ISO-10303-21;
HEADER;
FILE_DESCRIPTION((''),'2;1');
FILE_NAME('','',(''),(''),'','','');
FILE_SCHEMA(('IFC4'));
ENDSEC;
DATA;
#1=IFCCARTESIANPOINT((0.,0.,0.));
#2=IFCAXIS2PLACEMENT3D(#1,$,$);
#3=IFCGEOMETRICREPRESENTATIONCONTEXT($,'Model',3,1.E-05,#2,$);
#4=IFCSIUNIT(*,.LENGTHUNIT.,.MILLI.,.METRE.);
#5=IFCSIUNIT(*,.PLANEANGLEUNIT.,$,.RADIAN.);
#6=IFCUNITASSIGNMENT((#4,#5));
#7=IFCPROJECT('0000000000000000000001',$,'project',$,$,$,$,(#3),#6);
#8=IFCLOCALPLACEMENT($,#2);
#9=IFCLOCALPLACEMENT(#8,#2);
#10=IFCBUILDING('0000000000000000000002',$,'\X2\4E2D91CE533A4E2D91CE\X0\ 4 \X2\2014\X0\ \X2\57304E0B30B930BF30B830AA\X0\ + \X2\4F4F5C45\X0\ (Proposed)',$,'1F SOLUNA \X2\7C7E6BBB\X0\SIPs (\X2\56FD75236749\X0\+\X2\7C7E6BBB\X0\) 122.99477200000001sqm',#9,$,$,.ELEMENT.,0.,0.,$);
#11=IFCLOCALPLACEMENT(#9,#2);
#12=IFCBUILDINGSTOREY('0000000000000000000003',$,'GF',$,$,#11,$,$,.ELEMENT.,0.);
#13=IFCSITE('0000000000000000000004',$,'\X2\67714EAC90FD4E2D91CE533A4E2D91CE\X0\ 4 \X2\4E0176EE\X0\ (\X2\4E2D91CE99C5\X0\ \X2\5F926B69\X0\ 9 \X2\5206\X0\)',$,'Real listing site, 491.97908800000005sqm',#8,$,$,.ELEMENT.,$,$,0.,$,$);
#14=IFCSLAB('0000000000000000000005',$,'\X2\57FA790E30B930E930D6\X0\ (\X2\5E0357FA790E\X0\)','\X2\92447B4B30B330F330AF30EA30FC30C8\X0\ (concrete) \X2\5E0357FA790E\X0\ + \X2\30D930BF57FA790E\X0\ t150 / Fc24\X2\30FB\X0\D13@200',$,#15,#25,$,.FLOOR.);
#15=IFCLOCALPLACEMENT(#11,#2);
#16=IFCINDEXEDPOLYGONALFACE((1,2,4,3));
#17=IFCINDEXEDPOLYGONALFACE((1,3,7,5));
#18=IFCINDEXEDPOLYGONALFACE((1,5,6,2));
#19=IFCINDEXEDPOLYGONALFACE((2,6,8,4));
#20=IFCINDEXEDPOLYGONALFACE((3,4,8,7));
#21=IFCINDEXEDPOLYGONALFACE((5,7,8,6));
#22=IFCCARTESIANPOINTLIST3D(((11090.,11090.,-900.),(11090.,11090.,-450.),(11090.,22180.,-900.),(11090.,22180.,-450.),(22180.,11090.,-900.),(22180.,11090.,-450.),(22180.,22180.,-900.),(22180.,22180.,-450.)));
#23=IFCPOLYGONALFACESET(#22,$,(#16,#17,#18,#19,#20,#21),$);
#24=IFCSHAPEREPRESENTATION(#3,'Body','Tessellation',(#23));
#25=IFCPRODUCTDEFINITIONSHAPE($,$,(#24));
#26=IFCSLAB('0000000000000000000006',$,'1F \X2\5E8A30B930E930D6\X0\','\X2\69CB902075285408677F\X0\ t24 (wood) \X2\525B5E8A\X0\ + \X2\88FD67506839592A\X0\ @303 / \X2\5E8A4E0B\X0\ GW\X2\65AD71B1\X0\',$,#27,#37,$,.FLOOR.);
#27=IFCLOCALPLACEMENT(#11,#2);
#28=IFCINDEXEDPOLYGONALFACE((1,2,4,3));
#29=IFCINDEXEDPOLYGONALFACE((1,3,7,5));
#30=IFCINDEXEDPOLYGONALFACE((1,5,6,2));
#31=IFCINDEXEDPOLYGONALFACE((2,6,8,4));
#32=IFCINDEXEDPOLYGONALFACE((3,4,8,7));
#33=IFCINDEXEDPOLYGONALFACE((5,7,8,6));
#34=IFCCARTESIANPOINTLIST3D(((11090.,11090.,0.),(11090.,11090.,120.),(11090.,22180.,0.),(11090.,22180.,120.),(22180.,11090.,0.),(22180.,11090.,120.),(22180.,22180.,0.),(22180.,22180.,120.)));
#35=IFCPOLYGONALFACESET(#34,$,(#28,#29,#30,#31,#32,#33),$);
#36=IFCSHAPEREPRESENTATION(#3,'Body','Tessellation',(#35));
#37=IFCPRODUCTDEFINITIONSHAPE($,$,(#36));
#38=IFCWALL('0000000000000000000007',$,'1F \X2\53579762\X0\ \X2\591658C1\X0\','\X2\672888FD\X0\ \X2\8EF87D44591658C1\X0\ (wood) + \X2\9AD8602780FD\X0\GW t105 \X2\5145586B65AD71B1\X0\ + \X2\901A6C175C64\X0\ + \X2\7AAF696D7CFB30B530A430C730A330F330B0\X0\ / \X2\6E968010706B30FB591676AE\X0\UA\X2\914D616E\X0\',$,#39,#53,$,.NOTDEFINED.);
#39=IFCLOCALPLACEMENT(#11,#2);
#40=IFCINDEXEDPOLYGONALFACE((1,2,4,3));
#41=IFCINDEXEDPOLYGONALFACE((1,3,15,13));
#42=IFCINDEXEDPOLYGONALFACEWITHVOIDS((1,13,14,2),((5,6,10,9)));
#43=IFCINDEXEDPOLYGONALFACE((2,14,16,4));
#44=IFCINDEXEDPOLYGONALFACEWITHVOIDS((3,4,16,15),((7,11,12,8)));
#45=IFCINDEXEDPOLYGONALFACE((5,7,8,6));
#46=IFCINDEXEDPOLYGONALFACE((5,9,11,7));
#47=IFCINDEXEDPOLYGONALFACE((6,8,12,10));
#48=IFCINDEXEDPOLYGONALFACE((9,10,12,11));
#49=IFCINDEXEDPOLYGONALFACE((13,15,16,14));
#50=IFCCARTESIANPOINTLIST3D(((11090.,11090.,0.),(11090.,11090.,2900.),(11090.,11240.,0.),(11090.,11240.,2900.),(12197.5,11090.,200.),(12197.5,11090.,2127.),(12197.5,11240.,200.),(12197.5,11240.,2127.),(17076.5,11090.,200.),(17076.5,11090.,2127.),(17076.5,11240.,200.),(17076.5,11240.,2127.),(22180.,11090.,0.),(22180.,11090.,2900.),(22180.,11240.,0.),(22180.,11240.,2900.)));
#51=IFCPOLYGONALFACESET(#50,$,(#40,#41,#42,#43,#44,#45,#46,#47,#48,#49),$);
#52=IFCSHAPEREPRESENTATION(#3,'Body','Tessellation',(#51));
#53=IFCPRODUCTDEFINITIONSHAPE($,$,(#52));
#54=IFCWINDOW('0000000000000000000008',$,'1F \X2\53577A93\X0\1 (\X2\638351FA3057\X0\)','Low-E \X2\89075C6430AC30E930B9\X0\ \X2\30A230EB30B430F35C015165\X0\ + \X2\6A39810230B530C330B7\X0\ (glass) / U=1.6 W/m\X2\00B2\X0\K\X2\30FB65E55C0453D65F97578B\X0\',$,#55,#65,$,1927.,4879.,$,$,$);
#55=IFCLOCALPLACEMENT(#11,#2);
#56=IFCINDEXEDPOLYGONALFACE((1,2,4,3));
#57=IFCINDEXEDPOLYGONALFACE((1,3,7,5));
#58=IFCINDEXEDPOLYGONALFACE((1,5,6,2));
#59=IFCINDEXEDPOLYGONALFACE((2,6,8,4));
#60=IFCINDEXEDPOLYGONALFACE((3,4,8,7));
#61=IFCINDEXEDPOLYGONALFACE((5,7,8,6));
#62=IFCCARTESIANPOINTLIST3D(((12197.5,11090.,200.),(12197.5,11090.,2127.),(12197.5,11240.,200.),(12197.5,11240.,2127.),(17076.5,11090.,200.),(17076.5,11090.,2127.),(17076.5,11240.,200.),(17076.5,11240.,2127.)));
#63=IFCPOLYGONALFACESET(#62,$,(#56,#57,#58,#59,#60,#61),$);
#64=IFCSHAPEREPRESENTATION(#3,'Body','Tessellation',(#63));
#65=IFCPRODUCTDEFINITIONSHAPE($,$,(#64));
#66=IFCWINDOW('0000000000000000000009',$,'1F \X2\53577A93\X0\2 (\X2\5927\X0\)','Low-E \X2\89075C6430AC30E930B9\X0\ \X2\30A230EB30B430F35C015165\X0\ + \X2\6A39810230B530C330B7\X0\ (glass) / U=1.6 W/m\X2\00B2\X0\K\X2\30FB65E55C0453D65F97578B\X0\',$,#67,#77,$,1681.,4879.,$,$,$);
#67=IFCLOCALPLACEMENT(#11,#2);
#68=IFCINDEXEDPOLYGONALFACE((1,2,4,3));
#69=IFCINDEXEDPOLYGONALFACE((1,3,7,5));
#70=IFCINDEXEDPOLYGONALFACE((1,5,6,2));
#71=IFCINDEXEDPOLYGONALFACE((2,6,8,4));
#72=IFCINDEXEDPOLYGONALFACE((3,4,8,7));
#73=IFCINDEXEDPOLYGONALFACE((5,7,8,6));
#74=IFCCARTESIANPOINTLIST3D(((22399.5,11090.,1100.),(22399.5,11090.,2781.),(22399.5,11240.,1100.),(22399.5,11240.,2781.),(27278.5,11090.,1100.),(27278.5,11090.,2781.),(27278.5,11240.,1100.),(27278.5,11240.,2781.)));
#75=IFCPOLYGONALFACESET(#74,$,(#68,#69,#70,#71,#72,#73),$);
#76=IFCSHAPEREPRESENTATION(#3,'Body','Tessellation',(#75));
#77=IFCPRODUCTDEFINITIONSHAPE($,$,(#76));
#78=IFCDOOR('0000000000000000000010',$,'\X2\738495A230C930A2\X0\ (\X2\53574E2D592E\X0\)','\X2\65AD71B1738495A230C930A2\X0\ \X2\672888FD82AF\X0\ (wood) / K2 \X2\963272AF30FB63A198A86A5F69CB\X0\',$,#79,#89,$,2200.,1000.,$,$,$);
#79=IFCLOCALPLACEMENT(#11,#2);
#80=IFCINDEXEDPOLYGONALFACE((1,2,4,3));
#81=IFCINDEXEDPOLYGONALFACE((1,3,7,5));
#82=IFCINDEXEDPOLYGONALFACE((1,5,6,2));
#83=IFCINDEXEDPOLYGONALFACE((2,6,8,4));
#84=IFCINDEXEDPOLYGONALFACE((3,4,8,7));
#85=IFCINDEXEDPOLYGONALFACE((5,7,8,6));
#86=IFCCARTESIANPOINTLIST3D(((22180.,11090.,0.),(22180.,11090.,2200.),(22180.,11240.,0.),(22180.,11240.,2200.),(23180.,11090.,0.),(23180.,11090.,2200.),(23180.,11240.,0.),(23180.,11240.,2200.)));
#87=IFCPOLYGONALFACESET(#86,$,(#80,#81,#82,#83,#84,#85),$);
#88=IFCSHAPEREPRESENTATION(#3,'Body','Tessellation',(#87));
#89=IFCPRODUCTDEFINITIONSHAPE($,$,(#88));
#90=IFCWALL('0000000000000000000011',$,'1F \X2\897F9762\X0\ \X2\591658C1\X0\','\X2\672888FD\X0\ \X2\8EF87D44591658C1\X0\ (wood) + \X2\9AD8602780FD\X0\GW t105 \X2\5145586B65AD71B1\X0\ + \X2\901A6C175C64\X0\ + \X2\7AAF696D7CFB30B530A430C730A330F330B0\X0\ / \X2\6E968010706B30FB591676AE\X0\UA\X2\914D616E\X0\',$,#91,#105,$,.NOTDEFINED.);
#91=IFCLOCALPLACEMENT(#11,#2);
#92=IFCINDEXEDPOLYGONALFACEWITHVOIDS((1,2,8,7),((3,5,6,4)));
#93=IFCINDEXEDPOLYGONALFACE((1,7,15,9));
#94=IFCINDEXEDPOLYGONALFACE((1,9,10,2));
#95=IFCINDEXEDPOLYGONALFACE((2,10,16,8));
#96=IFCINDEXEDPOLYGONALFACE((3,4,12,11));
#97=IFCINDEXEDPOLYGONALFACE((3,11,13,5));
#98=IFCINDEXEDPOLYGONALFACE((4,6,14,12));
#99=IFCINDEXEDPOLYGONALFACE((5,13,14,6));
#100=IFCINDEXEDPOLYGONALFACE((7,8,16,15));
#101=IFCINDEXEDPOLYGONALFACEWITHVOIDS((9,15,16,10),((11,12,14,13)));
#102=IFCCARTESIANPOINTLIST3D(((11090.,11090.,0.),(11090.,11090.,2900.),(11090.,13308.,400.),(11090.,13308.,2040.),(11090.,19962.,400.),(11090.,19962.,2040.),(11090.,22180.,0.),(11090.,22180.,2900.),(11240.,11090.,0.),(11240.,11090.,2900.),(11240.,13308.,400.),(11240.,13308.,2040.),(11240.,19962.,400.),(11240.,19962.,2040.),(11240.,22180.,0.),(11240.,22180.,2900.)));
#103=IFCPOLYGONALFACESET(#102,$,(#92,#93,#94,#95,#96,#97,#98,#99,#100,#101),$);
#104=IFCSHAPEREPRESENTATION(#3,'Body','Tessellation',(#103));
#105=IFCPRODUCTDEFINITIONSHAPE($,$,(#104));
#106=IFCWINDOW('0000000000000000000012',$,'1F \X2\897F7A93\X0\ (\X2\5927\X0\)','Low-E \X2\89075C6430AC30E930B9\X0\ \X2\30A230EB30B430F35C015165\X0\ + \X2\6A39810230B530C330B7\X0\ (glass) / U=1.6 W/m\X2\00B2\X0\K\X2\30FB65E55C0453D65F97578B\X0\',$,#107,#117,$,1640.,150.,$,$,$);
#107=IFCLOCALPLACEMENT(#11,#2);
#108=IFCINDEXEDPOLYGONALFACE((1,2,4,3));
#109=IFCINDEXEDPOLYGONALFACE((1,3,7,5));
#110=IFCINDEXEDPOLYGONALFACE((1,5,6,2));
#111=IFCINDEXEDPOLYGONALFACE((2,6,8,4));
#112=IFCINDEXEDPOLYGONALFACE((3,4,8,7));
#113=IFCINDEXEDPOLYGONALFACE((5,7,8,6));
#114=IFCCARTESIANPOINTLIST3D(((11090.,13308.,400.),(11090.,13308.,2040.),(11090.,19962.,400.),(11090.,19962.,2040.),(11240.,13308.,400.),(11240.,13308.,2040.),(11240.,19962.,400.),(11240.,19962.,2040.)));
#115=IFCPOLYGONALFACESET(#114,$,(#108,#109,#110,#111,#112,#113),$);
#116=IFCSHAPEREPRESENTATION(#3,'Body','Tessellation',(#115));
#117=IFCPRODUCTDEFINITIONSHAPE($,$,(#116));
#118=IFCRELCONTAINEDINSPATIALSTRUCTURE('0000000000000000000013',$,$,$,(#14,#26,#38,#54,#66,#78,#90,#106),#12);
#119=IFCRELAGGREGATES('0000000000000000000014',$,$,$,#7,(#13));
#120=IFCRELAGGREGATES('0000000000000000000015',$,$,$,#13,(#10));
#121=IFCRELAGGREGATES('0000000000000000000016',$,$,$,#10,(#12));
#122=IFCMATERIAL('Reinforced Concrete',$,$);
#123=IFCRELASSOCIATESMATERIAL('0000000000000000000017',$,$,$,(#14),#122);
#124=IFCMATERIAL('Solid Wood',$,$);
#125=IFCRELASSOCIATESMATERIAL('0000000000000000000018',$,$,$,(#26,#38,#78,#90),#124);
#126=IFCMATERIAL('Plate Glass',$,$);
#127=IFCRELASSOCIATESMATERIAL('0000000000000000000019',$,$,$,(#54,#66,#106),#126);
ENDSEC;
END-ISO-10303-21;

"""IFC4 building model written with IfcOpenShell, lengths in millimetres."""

from ifc_helpers import new_model, si_unit, frame, frame_2d, origin, place, context, project, spatial, rectangle, extrude, material, element, fill, save


model = new_model("IFC4")

# Units and contexts
model_context = context("Model", 3, precision=1e-05, world=origin())
ifc_project = project(units=[si_unit("LENGTHUNIT", "METRE", prefix="MILLI"), si_unit("PLANEANGLEUNIT", "RADIAN")], contexts=[model_context])

# Site, building, storey
site_placement = place(None, origin())
site = spatial("IfcSite", under=ifc_project, at=site_placement, Name="東京都中野区中野 4 丁目 (中野駅 徒歩 9 分)", ObjectType="Real listing site, 491.97908800000005sqm", CompositionType="ELEMENT", RefElevation=0.0)
building_placement = place(site_placement, origin())
building = spatial("IfcBuilding", under=site, at=building_placement, Name="中野区中野 4 — 地下スタジオ + 住居 (Proposed)", ObjectType="1F SOLUNA 籾殻SIPs (国産杉+籾殻) 122.99477200000001sqm", CompositionType="ELEMENT", ElevationOfRefHeight=0.0, ElevationOfTerrain=0.0)
storey_placement = place(building_placement, origin())
storey = spatial("IfcBuildingStorey", under=building, at=storey_placement, Name="GF", CompositionType="ELEMENT", Elevation=0.0)

# Slabs
ifc_material_1 = material(Name="Reinforced Concrete")
slab_1_placement = place(storey_placement, frame((5545.0, 5545.0, -450.0)))
element("IfcSlab", 1, at=slab_1_placement, inside=storey, material=ifc_material_1, Name="基礎スラブ (布基礎)", Description="鉄筋コンクリート (concrete) 布基礎 + ベタ基礎 t150 / Fc24・D13@200", PredefinedType="FLOOR", context=model_context, shape_type="SweptSolid", body=[
    extrude(rectangle(XDim=11090.0, YDim=11090.0, at=frame_2d((5545.0, 5545.0))), frame((5545.0, 5545.0, -450.0)), (0.0, 0.0, 1.0), 450.0),
])
ifc_material_2 = material(Name="Solid Wood")
slab_2_placement = place(storey_placement, frame((5545.0, 5545.0, 0.0)))
element("IfcSlab", 2, at=slab_2_placement, inside=storey, material=ifc_material_2, Name="1F 床スラブ", Description="構造用合板 t24 (wood) 剛床 + 製材根太 @303 / 床下 GW断熱", PredefinedType="FLOOR", context=model_context, shape_type="SweptSolid", body=[
    extrude(rectangle(XDim=11090.0, YDim=11090.0, at=frame_2d((5545.0, 5545.0))), frame((5545.0, 5545.0, 0.0)), (0.0, 0.0, 1.0), 120.0),
])

# Wall, openings, windows, door
wall_1_placement = place(storey_placement, frame((5545.0, 5545.0, 0.0)))
wall_1 = element("IfcWall", 3, at=wall_1_placement, inside=storey, material=ifc_material_2, Name="1F 南面 外壁", Description="木製 軸組外壁 (wood) + 高性能GW t105 充填断熱 + 通気層 + 窯業系サイディング / 準耐火・外皮UA配慮", PredefinedType="NOTDEFINED", context=model_context, shape_type="SweptSolid", body=[
    extrude(rectangle(XDim=11090.0, YDim=150.0, at=frame_2d((5545.0, 75.0))), frame((5545.0, 5545.0, 0.0)), (0.0, 0.0, 1.0), 2900.0),
])
opening_1_placement = place(storey_placement, frame((6099.0, 5545.0, 100.0)))
opening_1 = element("IfcOpeningElement", 4, at=opening_1_placement, cuts=wall_1, PredefinedType="NOTDEFINED", context=model_context, shape_type="SweptSolid", body=[
    extrude(rectangle(XDim=4879.0, YDim=150.0, at=frame_2d((2439.0, 75.0))), frame((6099.0, 5545.0, 100.0)), (0.0, 0.0, 1.0), 1927.0),
])
opening_2_placement = place(storey_placement, frame((11200.0, 5545.0, 550.0)))
opening_2 = element("IfcOpeningElement", 5, at=opening_2_placement, cuts=wall_1, PredefinedType="NOTDEFINED", context=model_context, shape_type="SweptSolid", body=[
    extrude(rectangle(XDim=4879.0, YDim=150.0, at=frame_2d((2439.0, 75.0))), frame((11200.0, 5545.0, 550.0)), (0.0, 0.0, 1.0), 1681.0),
])
opening_3_placement = place(storey_placement, frame((11090.0, 5545.0, 0.0)))
opening_3 = element("IfcOpeningElement", 6, at=opening_3_placement, cuts=wall_1, PredefinedType="NOTDEFINED", context=model_context, shape_type="SweptSolid", body=[
    extrude(rectangle(XDim=1000.0, YDim=150.0, at=frame_2d((500.0, 75.0))), frame((11090.0, 5545.0, 0.0)), (0.0, 0.0, 1.0), 2200.0),
])
ifc_material_3 = material(Name="Plate Glass")
window_1_placement = place(storey_placement, frame((6099.0, 5545.0, 100.0)))
window_1 = element("IfcWindow", 7, at=window_1_placement, inside=storey, material=ifc_material_3, Name="1F 南窓1 (掃出し)", Description="Low-E 複層ガラス アルゴン封入 + 樹脂サッシ (glass) / U=1.6 W/m²K・日射取得型", OverallHeight=1927.0, OverallWidth=4879.0, context=model_context, shape_type="SweptSolid", body=[
    extrude(rectangle(XDim=4879.0, YDim=150.0, at=frame_2d((2439.0, 75.0))), frame((6099.0, 5545.0, 100.0)), (0.0, 0.0, 1.0), 1927.0),
])
fill(opening_1, window_1)
window_2_placement = place(storey_placement, frame((11200.0, 5545.0, 550.0)))
window_2 = element("IfcWindow", 8, at=window_2_placement, inside=storey, material=ifc_material_3, Name="1F 南窓2 (大)", Description="Low-E 複層ガラス アルゴン封入 + 樹脂サッシ (glass) / U=1.6 W/m²K・日射取得型", OverallHeight=1681.0, OverallWidth=4879.0, context=model_context, shape_type="SweptSolid", body=[
    extrude(rectangle(XDim=4879.0, YDim=150.0, at=frame_2d((2439.0, 75.0))), frame((11200.0, 5545.0, 550.0)), (0.0, 0.0, 1.0), 1681.0),
])
fill(opening_2, window_2)
door_placement = place(storey_placement, frame((11090.0, 5545.0, 0.0)))
door = element("IfcDoor", 9, at=door_placement, inside=storey, material=ifc_material_2, Name="玄関ドア (南中央)", Description="断熱玄関ドア 木製芯 (wood) / K2 防犯・採風機構", OverallHeight=2200.0, OverallWidth=1000.0, context=model_context, shape_type="SweptSolid", body=[
    extrude(rectangle(XDim=1000.0, YDim=150.0, at=frame_2d((500.0, 75.0))), frame((11090.0, 5545.0, 0.0)), (0.0, 0.0, 1.0), 2200.0),
])
fill(opening_3, door)

# Wall, opening, window
wall_2_placement = place(storey_placement, frame((5545.0, 5545.0, 0.0)))
wall_2 = element("IfcWall", 10, at=wall_2_placement, inside=storey, material=ifc_material_2, Name="1F 西面 外壁", Description="木製 軸組外壁 (wood) + 高性能GW t105 充填断熱 + 通気層 + 窯業系サイディング / 準耐火・外皮UA配慮", PredefinedType="NOTDEFINED", context=model_context, shape_type="SweptSolid", body=[
    extrude(rectangle(XDim=150.0, YDim=11090.0, at=frame_2d((75.0, 5545.0))), frame((5545.0, 5545.0, 0.0)), (0.0, 0.0, 1.0), 2900.0),
])
opening_4_placement = place(storey_placement, frame((5545.0, 6654.0, 200.0)))
opening_4 = element("IfcOpeningElement", 11, at=opening_4_placement, cuts=wall_2, PredefinedType="NOTDEFINED", context=model_context, shape_type="SweptSolid", body=[
    extrude(rectangle(XDim=150.0, YDim=6654.0, at=frame_2d((75.0, 3327.0))), frame((5545.0, 6654.0, 200.0)), (0.0, 0.0, 1.0), 1640.0),
])
window_3_placement = place(storey_placement, frame((5545.0, 6654.0, 200.0)))
window_3 = element("IfcWindow", 12, at=window_3_placement, inside=storey, material=ifc_material_3, Name="1F 西窓 (大)", Description="Low-E 複層ガラス アルゴン封入 + 樹脂サッシ (glass) / U=1.6 W/m²K・日射取得型", OverallHeight=1640.0, OverallWidth=150.0, context=model_context, shape_type="SweptSolid", body=[
    extrude(rectangle(XDim=150.0, YDim=6654.0, at=frame_2d((75.0, 3327.0))), frame((5545.0, 6654.0, 200.0)), (0.0, 0.0, 1.0), 1640.0),
])
fill(opening_4, window_3)

save(model, "model.ifc")
